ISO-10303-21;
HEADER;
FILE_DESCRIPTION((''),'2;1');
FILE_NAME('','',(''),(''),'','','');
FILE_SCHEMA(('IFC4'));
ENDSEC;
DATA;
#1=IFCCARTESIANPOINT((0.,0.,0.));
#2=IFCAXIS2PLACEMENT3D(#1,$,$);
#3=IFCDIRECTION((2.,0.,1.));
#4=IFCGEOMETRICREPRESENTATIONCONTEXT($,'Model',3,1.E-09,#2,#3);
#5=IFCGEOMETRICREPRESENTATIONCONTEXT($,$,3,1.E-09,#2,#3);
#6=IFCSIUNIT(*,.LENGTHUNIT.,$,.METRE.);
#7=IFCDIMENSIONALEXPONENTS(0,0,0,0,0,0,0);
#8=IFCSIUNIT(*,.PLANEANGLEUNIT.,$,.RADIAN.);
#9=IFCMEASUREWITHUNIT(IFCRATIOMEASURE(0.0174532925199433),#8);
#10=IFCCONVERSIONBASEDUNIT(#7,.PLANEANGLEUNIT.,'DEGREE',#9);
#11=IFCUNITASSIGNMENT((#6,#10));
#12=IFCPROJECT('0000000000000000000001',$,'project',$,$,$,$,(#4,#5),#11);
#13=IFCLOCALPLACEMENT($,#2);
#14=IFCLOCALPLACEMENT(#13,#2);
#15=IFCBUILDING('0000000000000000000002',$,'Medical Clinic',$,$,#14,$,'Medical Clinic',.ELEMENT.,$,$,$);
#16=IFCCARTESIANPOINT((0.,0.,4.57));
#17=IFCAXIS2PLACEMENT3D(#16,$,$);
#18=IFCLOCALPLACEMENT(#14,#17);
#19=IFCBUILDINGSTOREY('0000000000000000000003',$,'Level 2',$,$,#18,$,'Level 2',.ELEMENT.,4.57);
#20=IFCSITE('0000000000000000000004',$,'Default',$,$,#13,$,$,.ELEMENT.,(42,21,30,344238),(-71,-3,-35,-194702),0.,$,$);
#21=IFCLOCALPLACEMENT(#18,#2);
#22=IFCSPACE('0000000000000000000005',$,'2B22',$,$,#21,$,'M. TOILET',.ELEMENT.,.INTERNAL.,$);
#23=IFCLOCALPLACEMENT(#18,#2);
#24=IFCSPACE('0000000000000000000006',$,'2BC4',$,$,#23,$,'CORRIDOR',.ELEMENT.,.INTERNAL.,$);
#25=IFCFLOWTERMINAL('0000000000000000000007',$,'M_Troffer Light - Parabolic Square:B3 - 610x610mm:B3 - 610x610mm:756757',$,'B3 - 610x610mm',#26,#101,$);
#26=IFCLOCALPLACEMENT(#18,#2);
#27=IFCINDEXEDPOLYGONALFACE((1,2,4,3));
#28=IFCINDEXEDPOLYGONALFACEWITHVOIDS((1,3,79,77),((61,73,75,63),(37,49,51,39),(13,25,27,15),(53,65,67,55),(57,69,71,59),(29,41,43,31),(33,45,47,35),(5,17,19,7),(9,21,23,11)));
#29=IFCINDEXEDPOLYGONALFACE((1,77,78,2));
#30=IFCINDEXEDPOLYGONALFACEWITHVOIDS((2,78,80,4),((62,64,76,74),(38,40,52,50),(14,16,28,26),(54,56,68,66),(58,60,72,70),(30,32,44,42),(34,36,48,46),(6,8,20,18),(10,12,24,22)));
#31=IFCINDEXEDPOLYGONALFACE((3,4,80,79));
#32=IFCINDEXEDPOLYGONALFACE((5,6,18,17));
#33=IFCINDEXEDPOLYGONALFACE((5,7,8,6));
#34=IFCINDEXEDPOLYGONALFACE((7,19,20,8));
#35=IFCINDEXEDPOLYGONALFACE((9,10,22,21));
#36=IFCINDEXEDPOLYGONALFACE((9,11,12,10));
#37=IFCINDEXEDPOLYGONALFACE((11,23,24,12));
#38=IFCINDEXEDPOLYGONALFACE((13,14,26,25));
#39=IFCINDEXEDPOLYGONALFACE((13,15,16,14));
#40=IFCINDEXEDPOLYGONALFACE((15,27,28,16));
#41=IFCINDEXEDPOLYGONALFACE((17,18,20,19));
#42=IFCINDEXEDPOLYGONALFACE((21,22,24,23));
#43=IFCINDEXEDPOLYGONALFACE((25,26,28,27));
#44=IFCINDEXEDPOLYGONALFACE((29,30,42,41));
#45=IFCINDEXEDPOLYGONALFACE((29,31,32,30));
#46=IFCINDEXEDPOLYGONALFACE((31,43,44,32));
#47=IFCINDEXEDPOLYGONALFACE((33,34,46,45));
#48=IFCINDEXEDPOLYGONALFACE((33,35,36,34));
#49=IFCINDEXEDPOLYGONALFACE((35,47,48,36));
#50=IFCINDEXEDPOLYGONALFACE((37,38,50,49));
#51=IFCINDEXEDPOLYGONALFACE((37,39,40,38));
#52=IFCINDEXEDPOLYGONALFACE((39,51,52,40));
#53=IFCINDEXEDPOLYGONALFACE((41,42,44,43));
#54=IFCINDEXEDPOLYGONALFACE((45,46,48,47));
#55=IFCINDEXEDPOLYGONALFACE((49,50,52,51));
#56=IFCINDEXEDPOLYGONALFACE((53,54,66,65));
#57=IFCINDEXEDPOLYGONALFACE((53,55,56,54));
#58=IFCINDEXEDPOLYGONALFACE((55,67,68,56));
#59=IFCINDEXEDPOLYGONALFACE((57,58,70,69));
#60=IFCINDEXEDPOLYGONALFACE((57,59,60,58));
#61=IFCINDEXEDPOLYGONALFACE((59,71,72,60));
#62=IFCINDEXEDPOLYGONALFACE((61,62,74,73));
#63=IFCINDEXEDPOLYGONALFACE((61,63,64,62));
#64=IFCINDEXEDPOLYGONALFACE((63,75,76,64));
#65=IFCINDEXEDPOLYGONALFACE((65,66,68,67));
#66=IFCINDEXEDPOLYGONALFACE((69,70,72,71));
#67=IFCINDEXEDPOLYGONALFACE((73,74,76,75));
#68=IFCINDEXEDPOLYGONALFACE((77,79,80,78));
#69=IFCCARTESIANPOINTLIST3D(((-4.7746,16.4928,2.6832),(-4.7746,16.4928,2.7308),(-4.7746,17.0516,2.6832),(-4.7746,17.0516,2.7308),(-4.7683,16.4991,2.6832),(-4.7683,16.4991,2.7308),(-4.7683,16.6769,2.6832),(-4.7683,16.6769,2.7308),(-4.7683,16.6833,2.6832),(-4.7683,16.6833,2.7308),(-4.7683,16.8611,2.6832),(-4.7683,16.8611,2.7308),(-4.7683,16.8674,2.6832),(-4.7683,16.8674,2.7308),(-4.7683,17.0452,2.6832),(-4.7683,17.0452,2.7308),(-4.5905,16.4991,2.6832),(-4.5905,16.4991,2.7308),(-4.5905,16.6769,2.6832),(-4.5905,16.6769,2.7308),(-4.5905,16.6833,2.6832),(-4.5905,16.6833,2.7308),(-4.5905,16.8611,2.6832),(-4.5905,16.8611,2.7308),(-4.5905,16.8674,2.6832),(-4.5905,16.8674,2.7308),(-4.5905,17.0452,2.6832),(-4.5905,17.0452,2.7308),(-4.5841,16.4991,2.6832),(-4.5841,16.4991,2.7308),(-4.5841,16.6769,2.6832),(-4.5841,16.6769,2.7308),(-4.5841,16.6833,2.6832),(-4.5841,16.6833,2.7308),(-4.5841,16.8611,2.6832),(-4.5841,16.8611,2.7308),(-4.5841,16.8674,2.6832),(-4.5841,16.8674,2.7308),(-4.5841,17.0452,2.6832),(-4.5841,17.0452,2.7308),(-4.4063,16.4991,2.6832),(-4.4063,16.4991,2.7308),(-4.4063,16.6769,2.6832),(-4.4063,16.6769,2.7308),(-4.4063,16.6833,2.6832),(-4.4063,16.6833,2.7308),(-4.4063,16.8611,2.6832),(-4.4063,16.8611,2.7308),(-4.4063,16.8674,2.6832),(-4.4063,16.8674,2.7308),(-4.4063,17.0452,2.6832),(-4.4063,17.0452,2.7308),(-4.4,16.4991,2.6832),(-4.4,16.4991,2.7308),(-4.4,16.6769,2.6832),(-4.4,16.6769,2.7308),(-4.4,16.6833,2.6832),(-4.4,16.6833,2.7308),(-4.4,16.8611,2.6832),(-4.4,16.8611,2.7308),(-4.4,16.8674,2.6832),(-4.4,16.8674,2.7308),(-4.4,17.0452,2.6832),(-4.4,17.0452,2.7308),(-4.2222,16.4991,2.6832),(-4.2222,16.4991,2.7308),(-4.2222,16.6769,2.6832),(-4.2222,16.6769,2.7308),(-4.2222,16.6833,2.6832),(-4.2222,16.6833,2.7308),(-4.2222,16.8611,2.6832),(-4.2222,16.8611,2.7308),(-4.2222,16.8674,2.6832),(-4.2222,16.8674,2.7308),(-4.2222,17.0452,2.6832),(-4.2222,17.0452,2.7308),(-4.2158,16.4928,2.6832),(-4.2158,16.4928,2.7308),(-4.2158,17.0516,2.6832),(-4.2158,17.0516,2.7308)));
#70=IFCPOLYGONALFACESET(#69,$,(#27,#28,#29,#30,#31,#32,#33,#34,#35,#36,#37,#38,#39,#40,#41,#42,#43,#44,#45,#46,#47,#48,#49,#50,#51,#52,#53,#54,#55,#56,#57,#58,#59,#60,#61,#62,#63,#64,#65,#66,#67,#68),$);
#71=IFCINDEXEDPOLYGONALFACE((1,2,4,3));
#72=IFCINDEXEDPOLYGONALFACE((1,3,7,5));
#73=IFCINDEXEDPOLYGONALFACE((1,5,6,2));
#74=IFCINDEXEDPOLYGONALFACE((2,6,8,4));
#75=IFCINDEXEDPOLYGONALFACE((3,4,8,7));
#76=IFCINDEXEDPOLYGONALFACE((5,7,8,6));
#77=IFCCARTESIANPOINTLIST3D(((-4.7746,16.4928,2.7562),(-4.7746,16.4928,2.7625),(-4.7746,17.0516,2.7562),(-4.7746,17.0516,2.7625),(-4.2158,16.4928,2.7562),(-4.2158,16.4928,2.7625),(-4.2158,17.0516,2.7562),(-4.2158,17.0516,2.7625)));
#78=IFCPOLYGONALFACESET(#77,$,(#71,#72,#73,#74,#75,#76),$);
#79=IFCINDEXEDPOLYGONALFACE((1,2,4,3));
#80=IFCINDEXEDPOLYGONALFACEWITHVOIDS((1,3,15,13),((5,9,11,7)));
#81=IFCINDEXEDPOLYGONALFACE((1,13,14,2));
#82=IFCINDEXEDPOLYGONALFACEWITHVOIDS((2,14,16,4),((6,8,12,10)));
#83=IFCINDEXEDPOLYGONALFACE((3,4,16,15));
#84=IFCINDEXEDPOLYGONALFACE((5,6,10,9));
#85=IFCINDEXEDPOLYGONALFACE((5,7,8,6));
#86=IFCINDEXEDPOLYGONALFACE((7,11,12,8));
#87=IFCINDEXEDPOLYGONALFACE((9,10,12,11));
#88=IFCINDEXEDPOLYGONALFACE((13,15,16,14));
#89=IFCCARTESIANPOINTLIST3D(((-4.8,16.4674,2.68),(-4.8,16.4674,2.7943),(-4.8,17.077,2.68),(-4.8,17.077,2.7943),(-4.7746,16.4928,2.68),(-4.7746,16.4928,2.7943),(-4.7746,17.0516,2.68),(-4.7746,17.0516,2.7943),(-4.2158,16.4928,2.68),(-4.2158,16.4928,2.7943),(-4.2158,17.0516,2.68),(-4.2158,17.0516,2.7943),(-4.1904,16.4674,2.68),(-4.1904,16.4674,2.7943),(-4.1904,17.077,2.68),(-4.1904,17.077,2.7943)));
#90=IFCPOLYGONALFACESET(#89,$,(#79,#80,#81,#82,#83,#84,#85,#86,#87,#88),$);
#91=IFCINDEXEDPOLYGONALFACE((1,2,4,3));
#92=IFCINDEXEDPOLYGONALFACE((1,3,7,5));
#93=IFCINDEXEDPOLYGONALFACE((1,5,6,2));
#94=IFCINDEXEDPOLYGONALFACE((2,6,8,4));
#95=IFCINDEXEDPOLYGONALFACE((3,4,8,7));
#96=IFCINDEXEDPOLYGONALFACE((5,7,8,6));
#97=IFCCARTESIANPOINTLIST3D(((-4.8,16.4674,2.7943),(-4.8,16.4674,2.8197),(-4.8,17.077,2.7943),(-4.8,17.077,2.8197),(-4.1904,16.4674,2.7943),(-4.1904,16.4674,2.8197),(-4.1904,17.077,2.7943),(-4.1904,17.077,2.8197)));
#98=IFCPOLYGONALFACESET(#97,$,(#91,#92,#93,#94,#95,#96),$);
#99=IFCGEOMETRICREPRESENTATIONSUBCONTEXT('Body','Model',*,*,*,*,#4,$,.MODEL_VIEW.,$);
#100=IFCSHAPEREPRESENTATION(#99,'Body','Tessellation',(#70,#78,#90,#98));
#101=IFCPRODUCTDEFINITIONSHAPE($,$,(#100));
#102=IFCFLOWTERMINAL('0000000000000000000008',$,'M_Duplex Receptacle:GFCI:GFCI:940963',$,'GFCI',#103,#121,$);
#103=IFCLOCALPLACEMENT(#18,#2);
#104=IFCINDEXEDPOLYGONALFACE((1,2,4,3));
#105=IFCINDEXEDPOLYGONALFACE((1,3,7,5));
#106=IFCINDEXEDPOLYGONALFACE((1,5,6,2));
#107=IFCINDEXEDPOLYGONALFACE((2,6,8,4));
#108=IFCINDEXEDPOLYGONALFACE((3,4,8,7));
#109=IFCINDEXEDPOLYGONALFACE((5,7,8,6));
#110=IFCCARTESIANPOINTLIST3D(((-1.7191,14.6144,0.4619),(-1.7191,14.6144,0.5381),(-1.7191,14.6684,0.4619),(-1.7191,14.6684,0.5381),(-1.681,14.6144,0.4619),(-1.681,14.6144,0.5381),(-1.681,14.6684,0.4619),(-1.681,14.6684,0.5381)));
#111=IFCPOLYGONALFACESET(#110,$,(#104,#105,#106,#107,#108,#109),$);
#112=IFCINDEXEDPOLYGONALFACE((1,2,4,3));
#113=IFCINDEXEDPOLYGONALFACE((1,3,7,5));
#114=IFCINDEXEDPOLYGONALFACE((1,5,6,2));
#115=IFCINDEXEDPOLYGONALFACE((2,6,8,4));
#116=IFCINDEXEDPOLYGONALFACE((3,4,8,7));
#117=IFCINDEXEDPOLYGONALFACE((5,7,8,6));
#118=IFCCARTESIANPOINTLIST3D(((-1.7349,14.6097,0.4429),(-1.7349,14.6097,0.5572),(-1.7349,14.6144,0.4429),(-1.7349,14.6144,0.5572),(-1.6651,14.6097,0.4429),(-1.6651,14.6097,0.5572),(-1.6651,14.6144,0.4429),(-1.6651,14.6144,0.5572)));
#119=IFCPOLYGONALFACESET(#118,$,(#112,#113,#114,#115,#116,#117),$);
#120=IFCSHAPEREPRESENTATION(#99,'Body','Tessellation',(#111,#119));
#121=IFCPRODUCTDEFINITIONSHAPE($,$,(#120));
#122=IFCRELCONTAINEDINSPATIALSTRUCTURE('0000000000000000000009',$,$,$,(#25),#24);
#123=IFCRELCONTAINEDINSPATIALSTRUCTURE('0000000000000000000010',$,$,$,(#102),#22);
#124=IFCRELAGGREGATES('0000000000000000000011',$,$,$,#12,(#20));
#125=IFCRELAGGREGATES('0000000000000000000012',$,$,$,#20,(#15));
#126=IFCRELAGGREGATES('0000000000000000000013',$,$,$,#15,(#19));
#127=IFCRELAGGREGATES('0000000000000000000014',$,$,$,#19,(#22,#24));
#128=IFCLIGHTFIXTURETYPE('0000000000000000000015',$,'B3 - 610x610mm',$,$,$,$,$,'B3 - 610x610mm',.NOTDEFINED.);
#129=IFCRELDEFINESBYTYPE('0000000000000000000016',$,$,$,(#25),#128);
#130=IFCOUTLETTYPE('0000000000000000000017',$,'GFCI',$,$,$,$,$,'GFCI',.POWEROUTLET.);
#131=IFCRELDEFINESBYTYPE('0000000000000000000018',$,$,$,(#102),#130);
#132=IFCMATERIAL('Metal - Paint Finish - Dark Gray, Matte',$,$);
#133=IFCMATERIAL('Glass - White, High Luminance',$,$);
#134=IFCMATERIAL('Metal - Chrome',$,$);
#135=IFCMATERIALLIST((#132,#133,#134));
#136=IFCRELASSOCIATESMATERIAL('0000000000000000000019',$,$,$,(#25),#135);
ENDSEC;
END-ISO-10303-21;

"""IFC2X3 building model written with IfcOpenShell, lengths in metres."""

from ifc_helpers import new_model, entity, si_unit, converted_unit, direction, frame, frame_2d, origin, origin_2d_with_axis, place, context, subcontext, project, spatial, polyline, rectangle, outline, extrude, source, transform, mapped, material, material_list, type_object, type_shapes, element, save


model = new_model("IFC2X3")

# Units and contexts
model_context = context("Model", 3, precision=1e-09, world=origin(), true_north=direction((2.0, 0.0, 1.0)))
context_of_model = context(None, 3, precision=1e-09, world=origin(), true_north=direction((2.0, 0.0, 1.0)))
body_context = subcontext(model_context, "Body", "Model", "MODEL_VIEW")
ifc_project = project(units=[si_unit("LENGTHUNIT", "METRE"), converted_unit("PLANEANGLEUNIT", "DEGREE", entity("IfcRatioMeasure", 0.0174532925199433), si_unit("PLANEANGLEUNIT", "RADIAN"), dimensions=[0, 0, 0, 0, 0, 0, 0])], contexts=[model_context, context_of_model])

# Site, building, storey
site_placement = place(None, origin())
site = spatial("IfcSite", under=ifc_project, at=site_placement, Name="Default", CompositionType="ELEMENT", RefLatitude=(42, 21, 30, 344238), RefLongitude=(-71, -3, -35, -194702), RefElevation=0.0)
building_placement = place(site_placement, origin())
building = spatial("IfcBuilding", under=site, at=building_placement, Name="Medical Clinic", LongName="Medical Clinic", CompositionType="ELEMENT")
storey_placement = place(building_placement, frame((0.0, 0.0, 4.57)))
storey = spatial("IfcBuildingStorey", under=building, at=storey_placement, Name="Level 2", LongName="Level 2", CompositionType="ELEMENT", Elevation=4.57)

# Shared definitions
space_1_placement = place(storey_placement, origin())
space_1 = spatial("IfcSpace", under=storey, at=space_1_placement, Name="2B22", LongName="M. TOILET", CompositionType="ELEMENT", InteriorOrExteriorSpace="INTERNAL")

# Shared definitions
ifc_material_1 = material(Name="Metal - Paint Finish - Dark Gray, Matte")
ifc_material_2 = material(Name="Glass - White, High Luminance")
ifc_material_3 = material(Name="Metal - Chrome")
ifc_material_list_1 = material_list([ifc_material_1, ifc_material_2, ifc_material_3])
light_fixture_type_1 = type_object("IfcLightFixtureType", Name="B3 - 610x610mm", ElementType="B3 - 610x610mm", PredefinedType="NOTDEFINED")
shared_shape_1 = source(origin(), body_context, "Body", "SweptSolid", [
    extrude(outline(polyline([(-0.2794, -0.2794), (0.2794, -0.2794), (0.2794, 0.2794), (-0.2794, 0.2794), (-0.2794, -0.2794)]), holes=[polyline([(-0.0952, 0.0953), (-0.273, 0.0953), (-0.273, 0.2731), (-0.0952, 0.2731), (-0.0952, 0.0953)]), polyline([(0.2731, 0.0953), (0.0953, 0.0953), (0.0953, 0.2731), (0.2731, 0.2731), (0.2731, 0.0953)]), polyline([(-0.0889, 0.2731), (0.0889, 0.2731), (0.0889, 0.0953), (-0.0889, 0.0953), (-0.0889, 0.2731)]), polyline([(0.2731, -0.273), (0.0953, -0.273), (0.0953, -0.0952), (0.2731, -0.0952), (0.2731, -0.273)]), polyline([(0.0889, -0.273), (-0.0889, -0.273), (-0.0889, -0.0952), (0.0889, -0.0952), (0.0889, -0.273)]), polyline([(-0.0952, -0.273), (-0.273, -0.273), (-0.273, -0.0952), (-0.0952, -0.0952), (-0.0952, -0.273)]), polyline([(-0.0952, -0.0889), (-0.273, -0.0889), (-0.273, 0.0889), (-0.0952, 0.0889), (-0.0952, -0.0889)]), polyline([(0.0889, -0.0889), (-0.0889, -0.0889), (-0.0889, 0.0889), (0.0889, 0.0889), (0.0889, -0.0889)]), polyline([(0.2731, -0.0889), (0.0953, -0.0889), (0.0953, 0.0889), (0.2731, 0.0889), (0.2731, -0.0889)])]), frame((0.0, -0.3048, -0.0508), z_axis=(0.0, 0.0, 1.0), x_axis=(-1.0, 0.0, 0.0)), (0.0, 0.0, 1.0), 0.0476),
    extrude(rectangle(XDim=0.5588, YDim=0.5588, at=origin_2d_with_axis()), frame((0.0, -0.3048, -0.0825), z_axis=(0.0, 0.0, 1.0), x_axis=(-1.0, 0.0, 0.0)), (0.0, 0.0, 1.0), 0.0064),
    extrude(outline(polyline([(-0.3048, -0.3048), (0.3048, -0.3048), (0.3048, 0.3048), (-0.3048, 0.3048), (-0.3048, -0.3048)]), holes=[polyline([(0.2794, 0.2794), (0.2794, -0.2794), (-0.2794, -0.2794), (-0.2794, 0.2794), (0.2794, 0.2794)])]), frame((0.0, -0.3048, -0.1143)), (0.0, 0.0, 1.0), 0.1143),
    extrude(rectangle(XDim=0.6096, YDim=0.6096, at=origin_2d_with_axis()), frame((0.0, -0.3048, -0.1397), z_axis=(0.0, 0.0, 1.0), x_axis=(-1.0, 0.0, 0.0)), (0.0, 0.0, 1.0), 0.0254),
])
type_shapes(light_fixture_type_1, [shared_shape_1])

# Shared definitions
space_2_placement = place(storey_placement, origin())
space_2 = spatial("IfcSpace", under=storey, at=space_2_placement, Name="2BC4", LongName="CORRIDOR", CompositionType="ELEMENT", InteriorOrExteriorSpace="INTERNAL")

# Flow terminals
flow_terminal_1_placement = place(space_2_placement, frame((-4.4952, 16.4674, 2.68), z_axis=(0.0, 0.0, -1.0), x_axis=(1.0, 0.0, 0.0)))
element("IfcFlowTerminal", 1, at=flow_terminal_1_placement, inside=space_2, type_object=light_fixture_type_1, material=ifc_material_list_1, Name="M_Troffer Light - Parabolic Square:B3 - 610x610mm:B3 - 610x610mm:756757", ObjectType="B3 - 610x610mm", context=body_context, shape_type="MappedRepresentation", body=[
    mapped(shared_shape_1, transform((0.0, 0.0, 0.0), scale=1.0)),
])
outlet_type_1 = type_object("IfcOutletType", Name="GFCI", ElementType="GFCI", PredefinedType="POWEROUTLET")
shared_shape_2 = source(origin(), body_context, "Body", "SweptSolid", [
    extrude(rectangle(XDim=0.0381, YDim=0.0762, at=origin_2d_with_axis()), frame((0.0, 0.0, -0.054), z_axis=(0.0, 0.0, 1.0), x_axis=(-1.0, 0.0, 0.0)), (0.0, 0.0, 1.0), 0.054),
    extrude(rectangle(XDim=0.0698, YDim=0.1143, at=frame_2d((0.0, 0.0), x_axis=(1.0, 0.0))), frame((0.0, 0.0, 0.0), z_axis=(0.0, 0.0, 1.0), x_axis=(-1.0, 0.0, 0.0)), (0.0, 0.0, 1.0), 0.0048),
])
type_shapes(outlet_type_1, [shared_shape_2])
flow_terminal_2_placement = place(space_1_placement, frame((-1.7, 14.6144, 0.5), z_axis=(0.0, -1.0, 0.0), x_axis=(1.0, 0.0, 0.0)))
element("IfcFlowTerminal", 2, at=flow_terminal_2_placement, inside=space_1, type_object=outlet_type_1, Name="M_Duplex Receptacle:GFCI:GFCI:940963", ObjectType="GFCI", context=body_context, shape_type="MappedRepresentation", body=[
    mapped(shared_shape_2, transform((0.0, 0.0, 0.0), scale=1.0)),
])

save(model, "model.ifc")
